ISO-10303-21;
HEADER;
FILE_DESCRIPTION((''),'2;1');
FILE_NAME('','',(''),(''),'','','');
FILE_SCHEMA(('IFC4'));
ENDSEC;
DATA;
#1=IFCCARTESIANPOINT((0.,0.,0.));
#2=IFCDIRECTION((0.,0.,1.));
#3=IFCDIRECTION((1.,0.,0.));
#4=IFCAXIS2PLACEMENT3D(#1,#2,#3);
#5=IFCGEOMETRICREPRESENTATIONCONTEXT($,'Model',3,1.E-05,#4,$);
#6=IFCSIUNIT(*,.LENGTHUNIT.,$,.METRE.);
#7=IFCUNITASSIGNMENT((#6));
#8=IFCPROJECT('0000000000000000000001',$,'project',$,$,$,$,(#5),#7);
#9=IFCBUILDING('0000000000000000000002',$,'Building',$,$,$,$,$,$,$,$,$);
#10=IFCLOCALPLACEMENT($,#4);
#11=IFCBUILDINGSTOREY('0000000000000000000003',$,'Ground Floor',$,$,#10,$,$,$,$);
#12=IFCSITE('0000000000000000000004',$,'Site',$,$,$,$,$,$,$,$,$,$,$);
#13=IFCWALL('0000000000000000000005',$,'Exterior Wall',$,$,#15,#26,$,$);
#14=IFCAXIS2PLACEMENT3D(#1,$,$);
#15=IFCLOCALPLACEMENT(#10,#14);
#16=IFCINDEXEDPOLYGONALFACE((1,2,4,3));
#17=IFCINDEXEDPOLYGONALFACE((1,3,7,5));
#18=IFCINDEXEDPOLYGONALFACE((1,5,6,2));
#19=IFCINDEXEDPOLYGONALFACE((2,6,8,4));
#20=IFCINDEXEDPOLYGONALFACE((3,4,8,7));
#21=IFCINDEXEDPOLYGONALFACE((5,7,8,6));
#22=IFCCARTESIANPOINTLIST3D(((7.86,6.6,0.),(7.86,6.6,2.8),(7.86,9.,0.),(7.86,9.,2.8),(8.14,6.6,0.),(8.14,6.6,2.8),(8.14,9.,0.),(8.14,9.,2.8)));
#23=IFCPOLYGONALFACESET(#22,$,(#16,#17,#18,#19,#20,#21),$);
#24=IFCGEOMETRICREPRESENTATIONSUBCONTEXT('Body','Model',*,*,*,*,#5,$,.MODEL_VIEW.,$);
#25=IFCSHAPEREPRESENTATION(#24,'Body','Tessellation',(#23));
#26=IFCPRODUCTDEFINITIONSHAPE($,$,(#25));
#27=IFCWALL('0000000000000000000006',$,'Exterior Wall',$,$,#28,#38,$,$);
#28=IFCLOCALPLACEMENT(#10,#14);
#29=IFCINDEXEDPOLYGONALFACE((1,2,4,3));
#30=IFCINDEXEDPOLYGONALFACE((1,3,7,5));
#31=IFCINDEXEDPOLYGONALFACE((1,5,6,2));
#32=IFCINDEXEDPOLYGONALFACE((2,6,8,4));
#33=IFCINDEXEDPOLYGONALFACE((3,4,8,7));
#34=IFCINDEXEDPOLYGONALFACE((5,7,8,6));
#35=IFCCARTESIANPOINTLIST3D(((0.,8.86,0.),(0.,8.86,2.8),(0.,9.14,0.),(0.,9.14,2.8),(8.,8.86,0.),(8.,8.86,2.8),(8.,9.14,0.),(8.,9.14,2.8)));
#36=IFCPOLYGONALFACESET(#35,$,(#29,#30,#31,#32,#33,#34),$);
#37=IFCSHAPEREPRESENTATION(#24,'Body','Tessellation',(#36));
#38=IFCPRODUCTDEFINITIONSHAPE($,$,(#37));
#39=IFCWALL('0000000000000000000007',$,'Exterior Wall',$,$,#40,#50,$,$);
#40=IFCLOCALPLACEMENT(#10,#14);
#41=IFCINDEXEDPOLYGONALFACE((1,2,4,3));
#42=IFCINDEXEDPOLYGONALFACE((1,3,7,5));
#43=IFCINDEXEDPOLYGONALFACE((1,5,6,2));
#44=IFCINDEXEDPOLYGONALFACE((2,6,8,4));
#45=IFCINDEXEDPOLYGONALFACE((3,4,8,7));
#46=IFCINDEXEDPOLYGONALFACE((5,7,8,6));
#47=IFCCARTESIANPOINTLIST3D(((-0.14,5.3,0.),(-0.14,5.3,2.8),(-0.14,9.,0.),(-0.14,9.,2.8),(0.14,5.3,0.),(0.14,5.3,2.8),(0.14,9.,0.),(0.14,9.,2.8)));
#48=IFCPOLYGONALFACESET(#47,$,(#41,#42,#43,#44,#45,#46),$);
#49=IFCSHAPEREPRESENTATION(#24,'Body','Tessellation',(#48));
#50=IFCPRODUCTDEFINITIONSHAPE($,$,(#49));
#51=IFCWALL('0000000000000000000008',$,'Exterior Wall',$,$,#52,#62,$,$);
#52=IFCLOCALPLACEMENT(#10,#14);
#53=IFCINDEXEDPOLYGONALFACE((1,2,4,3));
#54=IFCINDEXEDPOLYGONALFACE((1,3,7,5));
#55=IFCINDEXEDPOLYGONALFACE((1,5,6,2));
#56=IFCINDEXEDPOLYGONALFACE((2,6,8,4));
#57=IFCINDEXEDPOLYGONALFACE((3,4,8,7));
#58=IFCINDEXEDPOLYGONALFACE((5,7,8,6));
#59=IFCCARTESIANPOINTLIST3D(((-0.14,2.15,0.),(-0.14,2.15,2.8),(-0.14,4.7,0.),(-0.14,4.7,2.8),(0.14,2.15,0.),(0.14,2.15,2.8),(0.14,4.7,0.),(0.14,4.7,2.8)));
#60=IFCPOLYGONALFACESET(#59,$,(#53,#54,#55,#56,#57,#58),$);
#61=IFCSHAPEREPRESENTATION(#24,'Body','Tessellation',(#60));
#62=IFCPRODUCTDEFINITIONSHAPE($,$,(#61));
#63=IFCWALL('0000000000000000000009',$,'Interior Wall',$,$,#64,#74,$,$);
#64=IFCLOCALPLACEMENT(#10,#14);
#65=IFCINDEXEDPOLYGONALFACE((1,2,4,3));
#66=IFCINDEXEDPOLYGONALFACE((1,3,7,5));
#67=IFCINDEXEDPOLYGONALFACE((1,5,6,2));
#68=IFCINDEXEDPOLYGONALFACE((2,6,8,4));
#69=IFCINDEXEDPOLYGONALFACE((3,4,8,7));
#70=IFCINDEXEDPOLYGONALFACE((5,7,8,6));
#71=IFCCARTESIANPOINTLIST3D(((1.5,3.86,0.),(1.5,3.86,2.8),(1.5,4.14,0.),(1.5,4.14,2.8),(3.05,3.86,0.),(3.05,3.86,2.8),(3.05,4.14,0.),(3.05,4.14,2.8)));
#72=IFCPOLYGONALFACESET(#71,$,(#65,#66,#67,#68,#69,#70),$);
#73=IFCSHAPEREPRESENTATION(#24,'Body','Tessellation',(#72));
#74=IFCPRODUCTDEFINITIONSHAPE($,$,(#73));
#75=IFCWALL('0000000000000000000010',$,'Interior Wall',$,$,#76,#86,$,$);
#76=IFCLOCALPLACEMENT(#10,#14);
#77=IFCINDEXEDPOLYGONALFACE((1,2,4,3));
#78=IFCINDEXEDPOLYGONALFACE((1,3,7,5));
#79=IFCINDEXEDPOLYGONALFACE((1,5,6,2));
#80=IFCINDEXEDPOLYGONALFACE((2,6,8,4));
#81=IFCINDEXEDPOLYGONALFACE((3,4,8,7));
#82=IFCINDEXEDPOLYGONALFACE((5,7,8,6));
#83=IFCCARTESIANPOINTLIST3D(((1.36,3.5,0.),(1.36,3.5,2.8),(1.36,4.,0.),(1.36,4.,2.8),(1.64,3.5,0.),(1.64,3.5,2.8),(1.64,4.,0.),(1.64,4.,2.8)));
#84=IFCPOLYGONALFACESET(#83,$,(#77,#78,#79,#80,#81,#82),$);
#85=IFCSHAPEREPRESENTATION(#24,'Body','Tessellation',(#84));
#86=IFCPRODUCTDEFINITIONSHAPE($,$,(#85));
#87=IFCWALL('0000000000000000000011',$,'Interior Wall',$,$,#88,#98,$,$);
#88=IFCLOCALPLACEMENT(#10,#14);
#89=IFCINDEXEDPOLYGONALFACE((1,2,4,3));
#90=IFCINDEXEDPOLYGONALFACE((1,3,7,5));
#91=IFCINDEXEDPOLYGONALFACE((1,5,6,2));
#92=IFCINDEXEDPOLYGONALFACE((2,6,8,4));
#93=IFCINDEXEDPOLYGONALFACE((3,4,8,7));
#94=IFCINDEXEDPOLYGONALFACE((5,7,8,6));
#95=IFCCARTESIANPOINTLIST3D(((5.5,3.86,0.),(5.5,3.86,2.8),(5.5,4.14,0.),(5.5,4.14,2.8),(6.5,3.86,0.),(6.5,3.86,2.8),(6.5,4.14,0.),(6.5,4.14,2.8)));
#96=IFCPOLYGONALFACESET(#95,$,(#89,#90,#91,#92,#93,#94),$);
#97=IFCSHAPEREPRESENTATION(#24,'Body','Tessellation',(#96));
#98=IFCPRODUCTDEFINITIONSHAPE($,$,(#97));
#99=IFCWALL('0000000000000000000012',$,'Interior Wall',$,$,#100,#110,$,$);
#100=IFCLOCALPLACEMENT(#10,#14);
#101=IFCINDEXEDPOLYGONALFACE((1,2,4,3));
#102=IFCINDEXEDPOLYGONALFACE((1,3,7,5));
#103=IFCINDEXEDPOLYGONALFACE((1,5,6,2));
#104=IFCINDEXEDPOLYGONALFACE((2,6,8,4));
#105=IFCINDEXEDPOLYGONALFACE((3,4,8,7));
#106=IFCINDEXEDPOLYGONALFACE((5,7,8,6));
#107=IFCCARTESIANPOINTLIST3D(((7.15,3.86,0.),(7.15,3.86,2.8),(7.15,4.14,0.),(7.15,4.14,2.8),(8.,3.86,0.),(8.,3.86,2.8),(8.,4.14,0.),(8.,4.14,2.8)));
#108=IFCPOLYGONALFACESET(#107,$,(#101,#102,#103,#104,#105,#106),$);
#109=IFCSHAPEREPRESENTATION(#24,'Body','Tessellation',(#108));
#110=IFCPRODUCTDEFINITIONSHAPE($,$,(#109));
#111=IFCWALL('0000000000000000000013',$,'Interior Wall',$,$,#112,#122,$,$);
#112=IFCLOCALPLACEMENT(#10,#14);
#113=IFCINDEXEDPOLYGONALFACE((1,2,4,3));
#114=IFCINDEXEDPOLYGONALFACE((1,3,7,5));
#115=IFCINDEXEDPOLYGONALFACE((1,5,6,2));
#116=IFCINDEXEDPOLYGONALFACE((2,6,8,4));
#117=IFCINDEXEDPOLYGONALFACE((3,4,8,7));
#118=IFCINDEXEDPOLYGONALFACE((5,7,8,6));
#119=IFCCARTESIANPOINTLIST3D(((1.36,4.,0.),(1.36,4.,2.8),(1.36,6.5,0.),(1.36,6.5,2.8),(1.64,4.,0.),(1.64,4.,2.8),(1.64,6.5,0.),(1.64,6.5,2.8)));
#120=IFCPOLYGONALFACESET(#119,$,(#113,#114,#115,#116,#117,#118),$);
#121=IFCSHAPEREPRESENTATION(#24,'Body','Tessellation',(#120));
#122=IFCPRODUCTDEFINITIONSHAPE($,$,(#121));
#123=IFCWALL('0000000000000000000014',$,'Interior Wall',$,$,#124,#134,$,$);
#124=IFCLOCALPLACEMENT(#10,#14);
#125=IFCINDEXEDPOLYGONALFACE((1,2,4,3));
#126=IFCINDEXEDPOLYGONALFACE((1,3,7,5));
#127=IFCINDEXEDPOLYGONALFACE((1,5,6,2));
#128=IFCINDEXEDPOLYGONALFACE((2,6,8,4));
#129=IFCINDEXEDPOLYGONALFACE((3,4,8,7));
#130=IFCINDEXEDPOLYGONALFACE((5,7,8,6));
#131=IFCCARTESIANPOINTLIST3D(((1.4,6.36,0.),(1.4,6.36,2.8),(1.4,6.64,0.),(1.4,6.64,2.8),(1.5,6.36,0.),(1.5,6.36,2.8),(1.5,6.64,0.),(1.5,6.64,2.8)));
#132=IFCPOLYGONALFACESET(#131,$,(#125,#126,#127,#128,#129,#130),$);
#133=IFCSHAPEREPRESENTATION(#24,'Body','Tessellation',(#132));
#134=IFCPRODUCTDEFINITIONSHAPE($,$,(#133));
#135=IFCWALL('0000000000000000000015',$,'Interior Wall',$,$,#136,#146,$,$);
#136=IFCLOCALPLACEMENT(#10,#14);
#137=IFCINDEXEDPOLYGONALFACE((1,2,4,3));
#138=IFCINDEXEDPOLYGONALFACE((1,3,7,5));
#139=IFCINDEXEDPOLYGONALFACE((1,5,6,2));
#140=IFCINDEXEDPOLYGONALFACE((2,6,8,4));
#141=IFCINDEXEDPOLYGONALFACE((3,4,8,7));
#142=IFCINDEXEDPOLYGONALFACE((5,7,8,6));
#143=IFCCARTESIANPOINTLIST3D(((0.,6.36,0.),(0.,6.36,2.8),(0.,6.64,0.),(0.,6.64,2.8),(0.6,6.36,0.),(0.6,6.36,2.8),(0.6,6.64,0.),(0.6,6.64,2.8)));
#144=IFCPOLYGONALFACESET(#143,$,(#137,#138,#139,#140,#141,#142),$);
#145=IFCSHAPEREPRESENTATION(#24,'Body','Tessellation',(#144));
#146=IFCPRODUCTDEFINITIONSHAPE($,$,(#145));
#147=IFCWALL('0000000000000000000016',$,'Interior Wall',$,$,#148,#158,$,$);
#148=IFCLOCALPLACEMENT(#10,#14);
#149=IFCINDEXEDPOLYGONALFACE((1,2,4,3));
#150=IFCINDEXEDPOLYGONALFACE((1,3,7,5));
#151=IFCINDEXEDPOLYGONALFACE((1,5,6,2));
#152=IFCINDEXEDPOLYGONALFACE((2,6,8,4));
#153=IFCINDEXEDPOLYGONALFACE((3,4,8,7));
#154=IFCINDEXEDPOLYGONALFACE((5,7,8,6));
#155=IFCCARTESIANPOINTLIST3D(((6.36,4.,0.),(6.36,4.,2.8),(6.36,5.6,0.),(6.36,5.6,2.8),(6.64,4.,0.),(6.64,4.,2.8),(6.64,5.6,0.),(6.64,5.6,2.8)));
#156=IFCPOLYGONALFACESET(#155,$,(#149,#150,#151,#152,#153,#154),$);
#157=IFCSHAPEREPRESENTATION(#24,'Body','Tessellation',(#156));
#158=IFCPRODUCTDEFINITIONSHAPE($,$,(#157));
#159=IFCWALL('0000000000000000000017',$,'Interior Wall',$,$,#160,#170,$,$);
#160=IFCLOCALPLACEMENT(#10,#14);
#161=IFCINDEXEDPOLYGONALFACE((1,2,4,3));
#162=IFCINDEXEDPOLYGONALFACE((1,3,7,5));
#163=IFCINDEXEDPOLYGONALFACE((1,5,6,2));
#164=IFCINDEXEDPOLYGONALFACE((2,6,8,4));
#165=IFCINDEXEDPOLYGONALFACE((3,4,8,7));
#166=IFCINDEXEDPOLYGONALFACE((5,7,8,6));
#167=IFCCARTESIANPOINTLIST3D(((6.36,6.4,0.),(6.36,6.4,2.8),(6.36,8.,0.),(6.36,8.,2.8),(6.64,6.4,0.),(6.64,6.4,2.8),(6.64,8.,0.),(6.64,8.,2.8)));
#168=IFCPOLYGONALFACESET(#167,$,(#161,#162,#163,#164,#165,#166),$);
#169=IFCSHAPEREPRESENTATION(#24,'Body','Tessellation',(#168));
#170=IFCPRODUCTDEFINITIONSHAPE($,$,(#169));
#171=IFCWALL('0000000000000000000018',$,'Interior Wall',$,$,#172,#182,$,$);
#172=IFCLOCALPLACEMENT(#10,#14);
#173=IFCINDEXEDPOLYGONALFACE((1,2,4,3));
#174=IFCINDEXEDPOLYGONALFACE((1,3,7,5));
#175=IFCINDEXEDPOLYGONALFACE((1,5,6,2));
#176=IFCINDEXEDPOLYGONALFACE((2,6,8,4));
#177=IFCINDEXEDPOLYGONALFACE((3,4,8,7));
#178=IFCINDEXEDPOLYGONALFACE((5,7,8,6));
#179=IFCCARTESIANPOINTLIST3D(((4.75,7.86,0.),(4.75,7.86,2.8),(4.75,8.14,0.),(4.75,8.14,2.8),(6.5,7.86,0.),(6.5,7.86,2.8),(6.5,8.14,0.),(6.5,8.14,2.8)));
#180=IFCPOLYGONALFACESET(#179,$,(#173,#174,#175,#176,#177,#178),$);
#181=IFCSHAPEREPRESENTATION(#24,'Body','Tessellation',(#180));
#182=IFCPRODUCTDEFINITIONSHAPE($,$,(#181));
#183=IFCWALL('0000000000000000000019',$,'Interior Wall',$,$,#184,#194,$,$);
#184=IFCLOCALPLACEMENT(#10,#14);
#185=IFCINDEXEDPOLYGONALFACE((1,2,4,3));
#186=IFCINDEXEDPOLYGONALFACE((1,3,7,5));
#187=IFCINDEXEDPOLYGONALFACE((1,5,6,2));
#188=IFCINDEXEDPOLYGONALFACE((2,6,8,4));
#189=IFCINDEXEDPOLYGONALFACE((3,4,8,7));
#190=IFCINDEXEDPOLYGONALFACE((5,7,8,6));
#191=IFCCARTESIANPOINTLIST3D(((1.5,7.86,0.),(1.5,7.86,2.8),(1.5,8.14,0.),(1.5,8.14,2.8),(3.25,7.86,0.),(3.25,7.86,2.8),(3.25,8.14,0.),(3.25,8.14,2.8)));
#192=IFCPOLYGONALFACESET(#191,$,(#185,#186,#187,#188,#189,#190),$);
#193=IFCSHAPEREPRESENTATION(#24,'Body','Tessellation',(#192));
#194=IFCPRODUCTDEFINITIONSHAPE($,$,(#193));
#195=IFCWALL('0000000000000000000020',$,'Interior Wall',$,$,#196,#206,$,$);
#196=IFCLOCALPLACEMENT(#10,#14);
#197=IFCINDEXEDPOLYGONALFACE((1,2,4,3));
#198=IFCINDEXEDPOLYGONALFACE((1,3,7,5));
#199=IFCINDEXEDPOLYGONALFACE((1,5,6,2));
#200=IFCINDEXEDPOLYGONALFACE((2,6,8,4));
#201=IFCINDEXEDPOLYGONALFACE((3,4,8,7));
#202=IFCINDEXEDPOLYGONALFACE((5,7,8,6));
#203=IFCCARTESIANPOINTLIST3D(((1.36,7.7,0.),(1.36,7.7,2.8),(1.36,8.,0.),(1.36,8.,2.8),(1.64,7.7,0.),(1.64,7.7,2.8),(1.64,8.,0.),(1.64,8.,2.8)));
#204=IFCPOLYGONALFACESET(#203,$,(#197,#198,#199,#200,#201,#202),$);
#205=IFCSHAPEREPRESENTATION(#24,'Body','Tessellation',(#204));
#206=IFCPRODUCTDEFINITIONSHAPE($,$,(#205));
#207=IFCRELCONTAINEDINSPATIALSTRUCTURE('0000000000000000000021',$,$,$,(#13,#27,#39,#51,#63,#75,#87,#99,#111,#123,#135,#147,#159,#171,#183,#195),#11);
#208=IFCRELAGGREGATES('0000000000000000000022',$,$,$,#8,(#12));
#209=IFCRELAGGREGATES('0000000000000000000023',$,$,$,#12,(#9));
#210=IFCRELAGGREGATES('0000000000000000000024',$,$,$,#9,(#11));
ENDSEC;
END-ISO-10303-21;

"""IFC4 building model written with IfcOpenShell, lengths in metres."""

from ifc_helpers import new_model, si_unit, frame, origin_with_axes, place, context, subcontext, project, spatial, indexed_curve, outline, extrude, element, save


model = new_model("IFC4")

# Units and contexts
model_context = context("Model", 3, precision=1e-05, world=origin_with_axes())
body_context = subcontext(model_context, "Body", "Model", "MODEL_VIEW")
ifc_project = project(units=[si_unit("LENGTHUNIT", "METRE")], contexts=[model_context])

# Site, building, storey
site = spatial("IfcSite", under=ifc_project, Name="Site")
building = spatial("IfcBuilding", under=site, Name="Building")
storey_placement = place(None, origin_with_axes())
storey = spatial("IfcBuildingStorey", under=building, at=storey_placement, Name="Ground Floor")

# Walls
wall_1_placement = place(storey_placement, frame((8.0, 6.6, 0.0), z_axis=(0.0, 0.0, 1.0), x_axis=(0.0, 1.0, 0.0)))
element("IfcWall", 1, at=wall_1_placement, inside=storey, Name="Exterior Wall", context=body_context, shape_type="SweptSolid", body=[
    extrude(outline(indexed_curve([(0.0, 0.0), (0.0, 0.28), (2.4, 0.28), (2.4, 0.0), (0.0, 0.0)], self_intersect=False)), frame((0.0, -0.14, 0.0), z_axis=(0.0, 0.0, 1.0), x_axis=(1.0, 0.0, 0.0)), (0.0, 0.0, 1.0), 2.8),
])
wall_2_placement = place(storey_placement, frame((8.0, 9.0, 0.0), z_axis=(0.0, 0.0, 1.0), x_axis=(-1.0, 0.0, 0.0)))
element("IfcWall", 2, at=wall_2_placement, inside=storey, Name="Exterior Wall", context=body_context, shape_type="SweptSolid", body=[
    extrude(outline(indexed_curve([(0.0, 0.0), (0.0, 0.28), (8.0, 0.28), (8.0, 0.0), (0.0, 0.0)], self_intersect=False)), frame((0.0, -0.14, 0.0), z_axis=(0.0, 0.0, 1.0), x_axis=(1.0, 0.0, 0.0)), (0.0, 0.0, 1.0), 2.8),
])
wall_3_placement = place(storey_placement, frame((0.0, 9.0, 0.0), z_axis=(0.0, 0.0, 1.0), x_axis=(0.0, -1.0, 0.0)))
element("IfcWall", 3, at=wall_3_placement, inside=storey, Name="Exterior Wall", context=body_context, shape_type="SweptSolid", body=[
    extrude(outline(indexed_curve([(0.0, 0.0), (0.0, 0.28), (3.7, 0.28), (3.7, 0.0), (0.0, 0.0)], self_intersect=False)), frame((0.0, -0.14, 0.0), z_axis=(0.0, 0.0, 1.0), x_axis=(1.0, 0.0, 0.0)), (0.0, 0.0, 1.0), 2.8),
])
wall_4_placement = place(storey_placement, frame((0.0, 4.7, 0.0), z_axis=(0.0, 0.0, 1.0), x_axis=(0.0, -1.0, 0.0)))
element("IfcWall", 4, at=wall_4_placement, inside=storey, Name="Exterior Wall", context=body_context, shape_type="SweptSolid", body=[
    extrude(outline(indexed_curve([(0.0, 0.0), (0.0, 0.28), (2.55, 0.28), (2.55, 0.0), (0.0, 0.0)], self_intersect=False)), frame((0.0, -0.14, 0.0), z_axis=(0.0, 0.0, 1.0), x_axis=(1.0, 0.0, 0.0)), (0.0, 0.0, 1.0), 2.8),
])
wall_5_placement = place(storey_placement, frame((3.05, 4.0, 0.0), z_axis=(0.0, 0.0, 1.0), x_axis=(-1.0, 0.0, 0.0)))
element("IfcWall", 5, at=wall_5_placement, inside=storey, Name="Interior Wall", context=body_context, shape_type="SweptSolid", body=[
    extrude(outline(indexed_curve([(0.0, 0.0), (0.0, 0.28), (1.55, 0.28), (1.55, 0.0), (0.0, 0.0)], self_intersect=False)), frame((0.0, -0.14, 0.0), z_axis=(0.0, 0.0, 1.0), x_axis=(1.0, 0.0, 0.0)), (0.0, 0.0, 1.0), 2.8),
])
wall_6_placement = place(storey_placement, frame((1.5, 4.0, 0.0), z_axis=(0.0, 0.0, 1.0), x_axis=(0.0, -1.0, 0.0)))
element("IfcWall", 6, at=wall_6_placement, inside=storey, Name="Interior Wall", context=body_context, shape_type="SweptSolid", body=[
    extrude(outline(indexed_curve([(0.0, 0.0), (0.0, 0.28), (0.5, 0.28), (0.5, 0.0), (0.0, 0.0)], self_intersect=False)), frame((0.0, -0.14, 0.0), z_axis=(0.0, 0.0, 1.0), x_axis=(1.0, 0.0, 0.0)), (0.0, 0.0, 1.0), 2.8),
])
wall_7_placement = place(storey_placement, frame((6.5, 4.0, 0.0), z_axis=(0.0, 0.0, 1.0), x_axis=(-1.0, 0.0, 0.0)))
element("IfcWall", 7, at=wall_7_placement, inside=storey, Name="Interior Wall", context=body_context, shape_type="SweptSolid", body=[
    extrude(outline(indexed_curve([(0.0, 0.0), (0.0, 0.28), (1.0, 0.28), (1.0, 0.0), (0.0, 0.0)], self_intersect=False)), frame((0.0, -0.14, 0.0), z_axis=(0.0, 0.0, 1.0), x_axis=(1.0, 0.0, 0.0)), (0.0, 0.0, 1.0), 2.8),
])
wall_8_placement = place(storey_placement, frame((8.0, 4.0, 0.0), z_axis=(0.0, 0.0, 1.0), x_axis=(-1.0, 0.0, 0.0)))
element("IfcWall", 8, at=wall_8_placement, inside=storey, Name="Interior Wall", context=body_context, shape_type="SweptSolid", body=[
    extrude(outline(indexed_curve([(0.0, 0.0), (0.0, 0.28), (0.85, 0.28), (0.85, 0.0), (0.0, 0.0)], self_intersect=False)), frame((0.0, -0.14, 0.0), z_axis=(0.0, 0.0, 1.0), x_axis=(1.0, 0.0, 0.0)), (0.0, 0.0, 1.0), 2.8),
])
wall_9_placement = place(storey_placement, frame((1.5, 4.0, 0.0), z_axis=(0.0, 0.0, 1.0), x_axis=(0.0, 1.0, 0.0)))
element("IfcWall", 9, at=wall_9_placement, inside=storey, Name="Interior Wall", context=body_context, shape_type="SweptSolid", body=[
    extrude(outline(indexed_curve([(0.0, 0.0), (0.0, 0.28), (2.5, 0.28), (2.5, 0.0), (0.0, 0.0)], self_intersect=False)), frame((0.0, -0.14, 0.0), z_axis=(0.0, 0.0, 1.0), x_axis=(1.0, 0.0, 0.0)), (0.0, 0.0, 1.0), 2.8),
])
wall_10_placement = place(storey_placement, frame((1.5, 6.5, 0.0), z_axis=(0.0, 0.0, 1.0), x_axis=(-1.0, 0.0, 0.0)))
element("IfcWall", 10, at=wall_10_placement, inside=storey, Name="Interior Wall", context=body_context, shape_type="SweptSolid", body=[
    extrude(outline(indexed_curve([(0.0, 0.0), (0.0, 0.28), (0.1, 0.28), (0.1, 0.0), (0.0, 0.0)], self_intersect=False)), frame((0.0, -0.14, 0.0), z_axis=(0.0, 0.0, 1.0), x_axis=(1.0, 0.0, 0.0)), (0.0, 0.0, 1.0), 2.8),
])
wall_11_placement = place(storey_placement, frame((0.6, 6.5, 0.0), z_axis=(0.0, 0.0, 1.0), x_axis=(-1.0, 0.0, 0.0)))
element("IfcWall", 11, at=wall_11_placement, inside=storey, Name="Interior Wall", context=body_context, shape_type="SweptSolid", body=[
    extrude(outline(indexed_curve([(0.0, 0.0), (0.0, 0.28), (0.6, 0.28), (0.6, 0.0), (0.0, 0.0)], self_intersect=False)), frame((0.0, -0.14, 0.0), z_axis=(0.0, 0.0, 1.0), x_axis=(1.0, 0.0, 0.0)), (0.0, 0.0, 1.0), 2.8),
])
for number, where, z_axis, x_axis, name in (
    (12, (6.5, 4.0, 0.0), (0.0, 0.0, 1.0), (0.0, 1.0, 0.0), "Interior Wall"),
    (13, (6.5, 6.4, 0.0), (0.0, 0.0, 1.0), (0.0, 1.0, 0.0), "Interior Wall"),
):
    element("IfcWall", number, at=place(storey_placement, frame(where, z_axis=z_axis, x_axis=x_axis)), inside=storey, Name=name, context=body_context, shape_type="SweptSolid", body=[
        extrude(outline(indexed_curve([(0.0, 0.0), (0.0, 0.28), (1.6, 0.28), (1.6, 0.0), (0.0, 0.0)], self_intersect=False)), frame((0.0, -0.14, 0.0), z_axis=(0.0, 0.0, 1.0), x_axis=(1.0, 0.0, 0.0)), (0.0, 0.0, 1.0), 2.8),
    ])
for number, where, z_axis, x_axis, name in (
    (14, (6.5, 8.0, 0.0), (0.0, 0.0, 1.0), (-1.0, 0.0, 0.0), "Interior Wall"),
    (15, (3.25, 8.0, 0.0), (0.0, 0.0, 1.0), (-1.0, 0.0, 0.0), "Interior Wall"),
):
    element("IfcWall", number, at=place(storey_placement, frame(where, z_axis=z_axis, x_axis=x_axis)), inside=storey, Name=name, context=body_context, shape_type="SweptSolid", body=[
        extrude(outline(indexed_curve([(0.0, 0.0), (0.0, 0.28), (1.75, 0.28), (1.75, 0.0), (0.0, 0.0)], self_intersect=False)), frame((0.0, -0.14, 0.0), z_axis=(0.0, 0.0, 1.0), x_axis=(1.0, 0.0, 0.0)), (0.0, 0.0, 1.0), 2.8),
    ])
for number, where, z_axis, x_axis, name in (
    (16, (1.5, 8.0, 0.0), (0.0, 0.0, 1.0), (0.0, -1.0, 0.0), "Interior Wall"),
):
    element("IfcWall", number, at=place(storey_placement, frame(where, z_axis=z_axis, x_axis=x_axis)), inside=storey, Name=name, context=body_context, shape_type="SweptSolid", body=[
        extrude(outline(indexed_curve([(0.0, 0.0), (0.0, 0.28), (0.3, 0.28), (0.3, 0.0), (0.0, 0.0)], self_intersect=False)), frame((0.0, -0.14, 0.0), z_axis=(0.0, 0.0, 1.0), x_axis=(1.0, 0.0, 0.0)), (0.0, 0.0, 1.0), 2.8),
    ])

save(model, "model.ifc")
